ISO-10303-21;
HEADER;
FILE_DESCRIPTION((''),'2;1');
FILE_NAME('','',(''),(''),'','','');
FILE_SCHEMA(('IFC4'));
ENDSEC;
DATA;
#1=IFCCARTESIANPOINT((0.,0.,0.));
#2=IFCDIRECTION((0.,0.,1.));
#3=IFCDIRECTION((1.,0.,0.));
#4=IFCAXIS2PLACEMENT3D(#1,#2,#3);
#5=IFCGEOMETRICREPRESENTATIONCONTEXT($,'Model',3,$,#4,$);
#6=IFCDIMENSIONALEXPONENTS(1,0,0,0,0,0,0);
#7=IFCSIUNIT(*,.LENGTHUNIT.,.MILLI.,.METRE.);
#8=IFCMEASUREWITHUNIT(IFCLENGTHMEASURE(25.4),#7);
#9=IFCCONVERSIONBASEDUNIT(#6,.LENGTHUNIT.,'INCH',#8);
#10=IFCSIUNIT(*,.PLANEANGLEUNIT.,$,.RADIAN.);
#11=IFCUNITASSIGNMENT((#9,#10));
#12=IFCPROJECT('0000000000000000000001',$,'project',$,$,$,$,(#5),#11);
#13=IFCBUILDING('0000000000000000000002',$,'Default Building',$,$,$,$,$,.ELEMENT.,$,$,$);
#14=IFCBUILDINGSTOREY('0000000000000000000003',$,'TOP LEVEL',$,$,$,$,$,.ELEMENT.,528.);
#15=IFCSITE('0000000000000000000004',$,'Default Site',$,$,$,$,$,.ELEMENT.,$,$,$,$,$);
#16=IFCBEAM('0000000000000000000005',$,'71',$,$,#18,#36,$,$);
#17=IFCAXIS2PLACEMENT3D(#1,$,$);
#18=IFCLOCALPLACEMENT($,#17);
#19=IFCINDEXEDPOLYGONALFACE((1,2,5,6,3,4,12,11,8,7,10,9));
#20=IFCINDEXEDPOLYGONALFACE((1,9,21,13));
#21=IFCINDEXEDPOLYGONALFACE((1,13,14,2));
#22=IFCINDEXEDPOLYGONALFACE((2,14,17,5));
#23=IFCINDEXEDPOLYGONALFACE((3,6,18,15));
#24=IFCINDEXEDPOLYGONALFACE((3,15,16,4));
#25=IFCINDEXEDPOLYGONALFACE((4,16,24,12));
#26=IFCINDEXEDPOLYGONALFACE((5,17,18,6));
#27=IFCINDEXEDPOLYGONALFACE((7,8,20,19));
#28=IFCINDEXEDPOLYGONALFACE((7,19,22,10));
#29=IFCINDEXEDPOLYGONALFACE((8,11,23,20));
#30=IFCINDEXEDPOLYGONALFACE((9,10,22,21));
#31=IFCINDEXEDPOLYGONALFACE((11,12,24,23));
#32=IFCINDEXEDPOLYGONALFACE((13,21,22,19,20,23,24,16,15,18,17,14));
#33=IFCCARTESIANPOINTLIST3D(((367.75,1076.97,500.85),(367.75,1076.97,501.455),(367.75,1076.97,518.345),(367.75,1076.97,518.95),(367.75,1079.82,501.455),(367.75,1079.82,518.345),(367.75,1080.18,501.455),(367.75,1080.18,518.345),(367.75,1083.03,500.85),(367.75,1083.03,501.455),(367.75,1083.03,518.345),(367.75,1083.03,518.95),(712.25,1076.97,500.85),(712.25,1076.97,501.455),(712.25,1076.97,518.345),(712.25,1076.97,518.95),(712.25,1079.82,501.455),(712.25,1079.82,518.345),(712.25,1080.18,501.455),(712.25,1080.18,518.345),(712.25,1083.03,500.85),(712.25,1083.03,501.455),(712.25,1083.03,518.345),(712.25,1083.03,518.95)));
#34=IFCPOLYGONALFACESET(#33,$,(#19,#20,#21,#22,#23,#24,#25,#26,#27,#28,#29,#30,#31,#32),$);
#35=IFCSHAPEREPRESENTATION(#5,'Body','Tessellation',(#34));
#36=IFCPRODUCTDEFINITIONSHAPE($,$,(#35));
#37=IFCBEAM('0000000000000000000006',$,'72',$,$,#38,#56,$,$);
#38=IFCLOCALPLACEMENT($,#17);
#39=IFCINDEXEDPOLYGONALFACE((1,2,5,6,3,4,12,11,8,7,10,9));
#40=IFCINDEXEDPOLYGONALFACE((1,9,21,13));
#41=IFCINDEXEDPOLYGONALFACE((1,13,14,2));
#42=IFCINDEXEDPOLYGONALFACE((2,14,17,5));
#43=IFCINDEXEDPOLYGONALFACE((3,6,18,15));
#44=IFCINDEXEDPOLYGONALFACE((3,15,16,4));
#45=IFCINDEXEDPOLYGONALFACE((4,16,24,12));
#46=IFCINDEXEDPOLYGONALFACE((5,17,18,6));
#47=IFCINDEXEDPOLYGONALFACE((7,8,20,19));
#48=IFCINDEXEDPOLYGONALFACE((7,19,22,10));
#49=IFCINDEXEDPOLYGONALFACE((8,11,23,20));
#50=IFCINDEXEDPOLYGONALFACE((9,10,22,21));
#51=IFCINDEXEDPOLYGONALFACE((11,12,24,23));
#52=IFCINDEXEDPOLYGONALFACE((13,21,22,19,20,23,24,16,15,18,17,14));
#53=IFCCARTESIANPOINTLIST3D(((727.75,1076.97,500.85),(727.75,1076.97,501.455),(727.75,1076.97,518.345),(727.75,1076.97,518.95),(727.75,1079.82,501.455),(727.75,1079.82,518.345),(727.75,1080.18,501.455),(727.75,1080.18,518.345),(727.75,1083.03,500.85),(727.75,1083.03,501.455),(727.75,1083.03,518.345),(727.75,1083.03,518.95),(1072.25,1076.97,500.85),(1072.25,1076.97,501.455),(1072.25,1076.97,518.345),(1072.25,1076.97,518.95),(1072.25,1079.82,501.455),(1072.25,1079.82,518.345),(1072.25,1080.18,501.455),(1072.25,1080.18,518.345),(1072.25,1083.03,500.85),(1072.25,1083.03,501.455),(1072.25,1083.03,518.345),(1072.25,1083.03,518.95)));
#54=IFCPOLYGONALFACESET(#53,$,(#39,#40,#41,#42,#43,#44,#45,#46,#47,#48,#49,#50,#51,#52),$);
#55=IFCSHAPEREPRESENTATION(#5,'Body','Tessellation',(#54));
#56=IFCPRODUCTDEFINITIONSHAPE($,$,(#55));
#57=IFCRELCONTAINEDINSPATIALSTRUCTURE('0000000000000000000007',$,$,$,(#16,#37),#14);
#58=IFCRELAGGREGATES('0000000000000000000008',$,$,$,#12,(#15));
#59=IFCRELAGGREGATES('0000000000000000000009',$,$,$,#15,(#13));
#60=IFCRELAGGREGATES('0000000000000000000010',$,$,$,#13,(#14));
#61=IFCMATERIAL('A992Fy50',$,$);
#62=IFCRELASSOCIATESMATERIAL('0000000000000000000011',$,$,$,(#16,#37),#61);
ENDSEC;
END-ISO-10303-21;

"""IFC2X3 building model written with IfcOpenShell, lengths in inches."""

from ifc_helpers import new_model, entity, si_unit, converted_unit, frame, origin_with_axes, origin_2d_with_axis, place, context, project, spatial, i_section, transform_2d, derived_profile, extrude, material, element, save


model = new_model("IFC2X3")

# Units and contexts
model_context = context("Model", 3, world=origin_with_axes())
ifc_project = project(units=[converted_unit("LENGTHUNIT", "INCH", entity("IfcLengthMeasure", 25.4), si_unit("LENGTHUNIT", "METRE", prefix="MILLI"), dimensions=[1, 0, 0, 0, 0, 0, 0]), si_unit("PLANEANGLEUNIT", "RADIAN")], contexts=[model_context])

# Site, building, storey
site = spatial("IfcSite", under=ifc_project, Name="Default Site", CompositionType="ELEMENT")
building = spatial("IfcBuilding", under=site, Name="Default Building", CompositionType="ELEMENT")
storey = spatial("IfcBuildingStorey", under=building, Name="TOP LEVEL", CompositionType="ELEMENT", Elevation=528.0)

# Beams
ifc_material = material(Name="A992Fy50")
for number, where, z_axis, x_axis, name in (
    (1, (367.75, 1080.0, 528.0), (1.0, 0.0, 0.0), (0.0, 1.0, 0.0), "71"),
    (2, (727.75, 1080.0, 528.0), (1.0, 0.0, 0.0), (0.0, 1.0, 0.0), "72"),
):
    element("IfcBeam", number, at=place(None, frame(where, z_axis=z_axis, x_axis=x_axis)), inside=storey, material=ifc_material, Name=name, context=model_context, shape_type="SweptSolid", body=[
        extrude(derived_profile(i_section(OverallWidth=6.06, OverallDepth=18.1, WebThickness=0.36, FlangeThickness=0.605, at=origin_2d_with_axis()), transform_2d((0.0, -9.05))), origin_with_axes(), (0.0, 0.0, 1.0), 344.5),
    ])

save(model, "model.ifc")
